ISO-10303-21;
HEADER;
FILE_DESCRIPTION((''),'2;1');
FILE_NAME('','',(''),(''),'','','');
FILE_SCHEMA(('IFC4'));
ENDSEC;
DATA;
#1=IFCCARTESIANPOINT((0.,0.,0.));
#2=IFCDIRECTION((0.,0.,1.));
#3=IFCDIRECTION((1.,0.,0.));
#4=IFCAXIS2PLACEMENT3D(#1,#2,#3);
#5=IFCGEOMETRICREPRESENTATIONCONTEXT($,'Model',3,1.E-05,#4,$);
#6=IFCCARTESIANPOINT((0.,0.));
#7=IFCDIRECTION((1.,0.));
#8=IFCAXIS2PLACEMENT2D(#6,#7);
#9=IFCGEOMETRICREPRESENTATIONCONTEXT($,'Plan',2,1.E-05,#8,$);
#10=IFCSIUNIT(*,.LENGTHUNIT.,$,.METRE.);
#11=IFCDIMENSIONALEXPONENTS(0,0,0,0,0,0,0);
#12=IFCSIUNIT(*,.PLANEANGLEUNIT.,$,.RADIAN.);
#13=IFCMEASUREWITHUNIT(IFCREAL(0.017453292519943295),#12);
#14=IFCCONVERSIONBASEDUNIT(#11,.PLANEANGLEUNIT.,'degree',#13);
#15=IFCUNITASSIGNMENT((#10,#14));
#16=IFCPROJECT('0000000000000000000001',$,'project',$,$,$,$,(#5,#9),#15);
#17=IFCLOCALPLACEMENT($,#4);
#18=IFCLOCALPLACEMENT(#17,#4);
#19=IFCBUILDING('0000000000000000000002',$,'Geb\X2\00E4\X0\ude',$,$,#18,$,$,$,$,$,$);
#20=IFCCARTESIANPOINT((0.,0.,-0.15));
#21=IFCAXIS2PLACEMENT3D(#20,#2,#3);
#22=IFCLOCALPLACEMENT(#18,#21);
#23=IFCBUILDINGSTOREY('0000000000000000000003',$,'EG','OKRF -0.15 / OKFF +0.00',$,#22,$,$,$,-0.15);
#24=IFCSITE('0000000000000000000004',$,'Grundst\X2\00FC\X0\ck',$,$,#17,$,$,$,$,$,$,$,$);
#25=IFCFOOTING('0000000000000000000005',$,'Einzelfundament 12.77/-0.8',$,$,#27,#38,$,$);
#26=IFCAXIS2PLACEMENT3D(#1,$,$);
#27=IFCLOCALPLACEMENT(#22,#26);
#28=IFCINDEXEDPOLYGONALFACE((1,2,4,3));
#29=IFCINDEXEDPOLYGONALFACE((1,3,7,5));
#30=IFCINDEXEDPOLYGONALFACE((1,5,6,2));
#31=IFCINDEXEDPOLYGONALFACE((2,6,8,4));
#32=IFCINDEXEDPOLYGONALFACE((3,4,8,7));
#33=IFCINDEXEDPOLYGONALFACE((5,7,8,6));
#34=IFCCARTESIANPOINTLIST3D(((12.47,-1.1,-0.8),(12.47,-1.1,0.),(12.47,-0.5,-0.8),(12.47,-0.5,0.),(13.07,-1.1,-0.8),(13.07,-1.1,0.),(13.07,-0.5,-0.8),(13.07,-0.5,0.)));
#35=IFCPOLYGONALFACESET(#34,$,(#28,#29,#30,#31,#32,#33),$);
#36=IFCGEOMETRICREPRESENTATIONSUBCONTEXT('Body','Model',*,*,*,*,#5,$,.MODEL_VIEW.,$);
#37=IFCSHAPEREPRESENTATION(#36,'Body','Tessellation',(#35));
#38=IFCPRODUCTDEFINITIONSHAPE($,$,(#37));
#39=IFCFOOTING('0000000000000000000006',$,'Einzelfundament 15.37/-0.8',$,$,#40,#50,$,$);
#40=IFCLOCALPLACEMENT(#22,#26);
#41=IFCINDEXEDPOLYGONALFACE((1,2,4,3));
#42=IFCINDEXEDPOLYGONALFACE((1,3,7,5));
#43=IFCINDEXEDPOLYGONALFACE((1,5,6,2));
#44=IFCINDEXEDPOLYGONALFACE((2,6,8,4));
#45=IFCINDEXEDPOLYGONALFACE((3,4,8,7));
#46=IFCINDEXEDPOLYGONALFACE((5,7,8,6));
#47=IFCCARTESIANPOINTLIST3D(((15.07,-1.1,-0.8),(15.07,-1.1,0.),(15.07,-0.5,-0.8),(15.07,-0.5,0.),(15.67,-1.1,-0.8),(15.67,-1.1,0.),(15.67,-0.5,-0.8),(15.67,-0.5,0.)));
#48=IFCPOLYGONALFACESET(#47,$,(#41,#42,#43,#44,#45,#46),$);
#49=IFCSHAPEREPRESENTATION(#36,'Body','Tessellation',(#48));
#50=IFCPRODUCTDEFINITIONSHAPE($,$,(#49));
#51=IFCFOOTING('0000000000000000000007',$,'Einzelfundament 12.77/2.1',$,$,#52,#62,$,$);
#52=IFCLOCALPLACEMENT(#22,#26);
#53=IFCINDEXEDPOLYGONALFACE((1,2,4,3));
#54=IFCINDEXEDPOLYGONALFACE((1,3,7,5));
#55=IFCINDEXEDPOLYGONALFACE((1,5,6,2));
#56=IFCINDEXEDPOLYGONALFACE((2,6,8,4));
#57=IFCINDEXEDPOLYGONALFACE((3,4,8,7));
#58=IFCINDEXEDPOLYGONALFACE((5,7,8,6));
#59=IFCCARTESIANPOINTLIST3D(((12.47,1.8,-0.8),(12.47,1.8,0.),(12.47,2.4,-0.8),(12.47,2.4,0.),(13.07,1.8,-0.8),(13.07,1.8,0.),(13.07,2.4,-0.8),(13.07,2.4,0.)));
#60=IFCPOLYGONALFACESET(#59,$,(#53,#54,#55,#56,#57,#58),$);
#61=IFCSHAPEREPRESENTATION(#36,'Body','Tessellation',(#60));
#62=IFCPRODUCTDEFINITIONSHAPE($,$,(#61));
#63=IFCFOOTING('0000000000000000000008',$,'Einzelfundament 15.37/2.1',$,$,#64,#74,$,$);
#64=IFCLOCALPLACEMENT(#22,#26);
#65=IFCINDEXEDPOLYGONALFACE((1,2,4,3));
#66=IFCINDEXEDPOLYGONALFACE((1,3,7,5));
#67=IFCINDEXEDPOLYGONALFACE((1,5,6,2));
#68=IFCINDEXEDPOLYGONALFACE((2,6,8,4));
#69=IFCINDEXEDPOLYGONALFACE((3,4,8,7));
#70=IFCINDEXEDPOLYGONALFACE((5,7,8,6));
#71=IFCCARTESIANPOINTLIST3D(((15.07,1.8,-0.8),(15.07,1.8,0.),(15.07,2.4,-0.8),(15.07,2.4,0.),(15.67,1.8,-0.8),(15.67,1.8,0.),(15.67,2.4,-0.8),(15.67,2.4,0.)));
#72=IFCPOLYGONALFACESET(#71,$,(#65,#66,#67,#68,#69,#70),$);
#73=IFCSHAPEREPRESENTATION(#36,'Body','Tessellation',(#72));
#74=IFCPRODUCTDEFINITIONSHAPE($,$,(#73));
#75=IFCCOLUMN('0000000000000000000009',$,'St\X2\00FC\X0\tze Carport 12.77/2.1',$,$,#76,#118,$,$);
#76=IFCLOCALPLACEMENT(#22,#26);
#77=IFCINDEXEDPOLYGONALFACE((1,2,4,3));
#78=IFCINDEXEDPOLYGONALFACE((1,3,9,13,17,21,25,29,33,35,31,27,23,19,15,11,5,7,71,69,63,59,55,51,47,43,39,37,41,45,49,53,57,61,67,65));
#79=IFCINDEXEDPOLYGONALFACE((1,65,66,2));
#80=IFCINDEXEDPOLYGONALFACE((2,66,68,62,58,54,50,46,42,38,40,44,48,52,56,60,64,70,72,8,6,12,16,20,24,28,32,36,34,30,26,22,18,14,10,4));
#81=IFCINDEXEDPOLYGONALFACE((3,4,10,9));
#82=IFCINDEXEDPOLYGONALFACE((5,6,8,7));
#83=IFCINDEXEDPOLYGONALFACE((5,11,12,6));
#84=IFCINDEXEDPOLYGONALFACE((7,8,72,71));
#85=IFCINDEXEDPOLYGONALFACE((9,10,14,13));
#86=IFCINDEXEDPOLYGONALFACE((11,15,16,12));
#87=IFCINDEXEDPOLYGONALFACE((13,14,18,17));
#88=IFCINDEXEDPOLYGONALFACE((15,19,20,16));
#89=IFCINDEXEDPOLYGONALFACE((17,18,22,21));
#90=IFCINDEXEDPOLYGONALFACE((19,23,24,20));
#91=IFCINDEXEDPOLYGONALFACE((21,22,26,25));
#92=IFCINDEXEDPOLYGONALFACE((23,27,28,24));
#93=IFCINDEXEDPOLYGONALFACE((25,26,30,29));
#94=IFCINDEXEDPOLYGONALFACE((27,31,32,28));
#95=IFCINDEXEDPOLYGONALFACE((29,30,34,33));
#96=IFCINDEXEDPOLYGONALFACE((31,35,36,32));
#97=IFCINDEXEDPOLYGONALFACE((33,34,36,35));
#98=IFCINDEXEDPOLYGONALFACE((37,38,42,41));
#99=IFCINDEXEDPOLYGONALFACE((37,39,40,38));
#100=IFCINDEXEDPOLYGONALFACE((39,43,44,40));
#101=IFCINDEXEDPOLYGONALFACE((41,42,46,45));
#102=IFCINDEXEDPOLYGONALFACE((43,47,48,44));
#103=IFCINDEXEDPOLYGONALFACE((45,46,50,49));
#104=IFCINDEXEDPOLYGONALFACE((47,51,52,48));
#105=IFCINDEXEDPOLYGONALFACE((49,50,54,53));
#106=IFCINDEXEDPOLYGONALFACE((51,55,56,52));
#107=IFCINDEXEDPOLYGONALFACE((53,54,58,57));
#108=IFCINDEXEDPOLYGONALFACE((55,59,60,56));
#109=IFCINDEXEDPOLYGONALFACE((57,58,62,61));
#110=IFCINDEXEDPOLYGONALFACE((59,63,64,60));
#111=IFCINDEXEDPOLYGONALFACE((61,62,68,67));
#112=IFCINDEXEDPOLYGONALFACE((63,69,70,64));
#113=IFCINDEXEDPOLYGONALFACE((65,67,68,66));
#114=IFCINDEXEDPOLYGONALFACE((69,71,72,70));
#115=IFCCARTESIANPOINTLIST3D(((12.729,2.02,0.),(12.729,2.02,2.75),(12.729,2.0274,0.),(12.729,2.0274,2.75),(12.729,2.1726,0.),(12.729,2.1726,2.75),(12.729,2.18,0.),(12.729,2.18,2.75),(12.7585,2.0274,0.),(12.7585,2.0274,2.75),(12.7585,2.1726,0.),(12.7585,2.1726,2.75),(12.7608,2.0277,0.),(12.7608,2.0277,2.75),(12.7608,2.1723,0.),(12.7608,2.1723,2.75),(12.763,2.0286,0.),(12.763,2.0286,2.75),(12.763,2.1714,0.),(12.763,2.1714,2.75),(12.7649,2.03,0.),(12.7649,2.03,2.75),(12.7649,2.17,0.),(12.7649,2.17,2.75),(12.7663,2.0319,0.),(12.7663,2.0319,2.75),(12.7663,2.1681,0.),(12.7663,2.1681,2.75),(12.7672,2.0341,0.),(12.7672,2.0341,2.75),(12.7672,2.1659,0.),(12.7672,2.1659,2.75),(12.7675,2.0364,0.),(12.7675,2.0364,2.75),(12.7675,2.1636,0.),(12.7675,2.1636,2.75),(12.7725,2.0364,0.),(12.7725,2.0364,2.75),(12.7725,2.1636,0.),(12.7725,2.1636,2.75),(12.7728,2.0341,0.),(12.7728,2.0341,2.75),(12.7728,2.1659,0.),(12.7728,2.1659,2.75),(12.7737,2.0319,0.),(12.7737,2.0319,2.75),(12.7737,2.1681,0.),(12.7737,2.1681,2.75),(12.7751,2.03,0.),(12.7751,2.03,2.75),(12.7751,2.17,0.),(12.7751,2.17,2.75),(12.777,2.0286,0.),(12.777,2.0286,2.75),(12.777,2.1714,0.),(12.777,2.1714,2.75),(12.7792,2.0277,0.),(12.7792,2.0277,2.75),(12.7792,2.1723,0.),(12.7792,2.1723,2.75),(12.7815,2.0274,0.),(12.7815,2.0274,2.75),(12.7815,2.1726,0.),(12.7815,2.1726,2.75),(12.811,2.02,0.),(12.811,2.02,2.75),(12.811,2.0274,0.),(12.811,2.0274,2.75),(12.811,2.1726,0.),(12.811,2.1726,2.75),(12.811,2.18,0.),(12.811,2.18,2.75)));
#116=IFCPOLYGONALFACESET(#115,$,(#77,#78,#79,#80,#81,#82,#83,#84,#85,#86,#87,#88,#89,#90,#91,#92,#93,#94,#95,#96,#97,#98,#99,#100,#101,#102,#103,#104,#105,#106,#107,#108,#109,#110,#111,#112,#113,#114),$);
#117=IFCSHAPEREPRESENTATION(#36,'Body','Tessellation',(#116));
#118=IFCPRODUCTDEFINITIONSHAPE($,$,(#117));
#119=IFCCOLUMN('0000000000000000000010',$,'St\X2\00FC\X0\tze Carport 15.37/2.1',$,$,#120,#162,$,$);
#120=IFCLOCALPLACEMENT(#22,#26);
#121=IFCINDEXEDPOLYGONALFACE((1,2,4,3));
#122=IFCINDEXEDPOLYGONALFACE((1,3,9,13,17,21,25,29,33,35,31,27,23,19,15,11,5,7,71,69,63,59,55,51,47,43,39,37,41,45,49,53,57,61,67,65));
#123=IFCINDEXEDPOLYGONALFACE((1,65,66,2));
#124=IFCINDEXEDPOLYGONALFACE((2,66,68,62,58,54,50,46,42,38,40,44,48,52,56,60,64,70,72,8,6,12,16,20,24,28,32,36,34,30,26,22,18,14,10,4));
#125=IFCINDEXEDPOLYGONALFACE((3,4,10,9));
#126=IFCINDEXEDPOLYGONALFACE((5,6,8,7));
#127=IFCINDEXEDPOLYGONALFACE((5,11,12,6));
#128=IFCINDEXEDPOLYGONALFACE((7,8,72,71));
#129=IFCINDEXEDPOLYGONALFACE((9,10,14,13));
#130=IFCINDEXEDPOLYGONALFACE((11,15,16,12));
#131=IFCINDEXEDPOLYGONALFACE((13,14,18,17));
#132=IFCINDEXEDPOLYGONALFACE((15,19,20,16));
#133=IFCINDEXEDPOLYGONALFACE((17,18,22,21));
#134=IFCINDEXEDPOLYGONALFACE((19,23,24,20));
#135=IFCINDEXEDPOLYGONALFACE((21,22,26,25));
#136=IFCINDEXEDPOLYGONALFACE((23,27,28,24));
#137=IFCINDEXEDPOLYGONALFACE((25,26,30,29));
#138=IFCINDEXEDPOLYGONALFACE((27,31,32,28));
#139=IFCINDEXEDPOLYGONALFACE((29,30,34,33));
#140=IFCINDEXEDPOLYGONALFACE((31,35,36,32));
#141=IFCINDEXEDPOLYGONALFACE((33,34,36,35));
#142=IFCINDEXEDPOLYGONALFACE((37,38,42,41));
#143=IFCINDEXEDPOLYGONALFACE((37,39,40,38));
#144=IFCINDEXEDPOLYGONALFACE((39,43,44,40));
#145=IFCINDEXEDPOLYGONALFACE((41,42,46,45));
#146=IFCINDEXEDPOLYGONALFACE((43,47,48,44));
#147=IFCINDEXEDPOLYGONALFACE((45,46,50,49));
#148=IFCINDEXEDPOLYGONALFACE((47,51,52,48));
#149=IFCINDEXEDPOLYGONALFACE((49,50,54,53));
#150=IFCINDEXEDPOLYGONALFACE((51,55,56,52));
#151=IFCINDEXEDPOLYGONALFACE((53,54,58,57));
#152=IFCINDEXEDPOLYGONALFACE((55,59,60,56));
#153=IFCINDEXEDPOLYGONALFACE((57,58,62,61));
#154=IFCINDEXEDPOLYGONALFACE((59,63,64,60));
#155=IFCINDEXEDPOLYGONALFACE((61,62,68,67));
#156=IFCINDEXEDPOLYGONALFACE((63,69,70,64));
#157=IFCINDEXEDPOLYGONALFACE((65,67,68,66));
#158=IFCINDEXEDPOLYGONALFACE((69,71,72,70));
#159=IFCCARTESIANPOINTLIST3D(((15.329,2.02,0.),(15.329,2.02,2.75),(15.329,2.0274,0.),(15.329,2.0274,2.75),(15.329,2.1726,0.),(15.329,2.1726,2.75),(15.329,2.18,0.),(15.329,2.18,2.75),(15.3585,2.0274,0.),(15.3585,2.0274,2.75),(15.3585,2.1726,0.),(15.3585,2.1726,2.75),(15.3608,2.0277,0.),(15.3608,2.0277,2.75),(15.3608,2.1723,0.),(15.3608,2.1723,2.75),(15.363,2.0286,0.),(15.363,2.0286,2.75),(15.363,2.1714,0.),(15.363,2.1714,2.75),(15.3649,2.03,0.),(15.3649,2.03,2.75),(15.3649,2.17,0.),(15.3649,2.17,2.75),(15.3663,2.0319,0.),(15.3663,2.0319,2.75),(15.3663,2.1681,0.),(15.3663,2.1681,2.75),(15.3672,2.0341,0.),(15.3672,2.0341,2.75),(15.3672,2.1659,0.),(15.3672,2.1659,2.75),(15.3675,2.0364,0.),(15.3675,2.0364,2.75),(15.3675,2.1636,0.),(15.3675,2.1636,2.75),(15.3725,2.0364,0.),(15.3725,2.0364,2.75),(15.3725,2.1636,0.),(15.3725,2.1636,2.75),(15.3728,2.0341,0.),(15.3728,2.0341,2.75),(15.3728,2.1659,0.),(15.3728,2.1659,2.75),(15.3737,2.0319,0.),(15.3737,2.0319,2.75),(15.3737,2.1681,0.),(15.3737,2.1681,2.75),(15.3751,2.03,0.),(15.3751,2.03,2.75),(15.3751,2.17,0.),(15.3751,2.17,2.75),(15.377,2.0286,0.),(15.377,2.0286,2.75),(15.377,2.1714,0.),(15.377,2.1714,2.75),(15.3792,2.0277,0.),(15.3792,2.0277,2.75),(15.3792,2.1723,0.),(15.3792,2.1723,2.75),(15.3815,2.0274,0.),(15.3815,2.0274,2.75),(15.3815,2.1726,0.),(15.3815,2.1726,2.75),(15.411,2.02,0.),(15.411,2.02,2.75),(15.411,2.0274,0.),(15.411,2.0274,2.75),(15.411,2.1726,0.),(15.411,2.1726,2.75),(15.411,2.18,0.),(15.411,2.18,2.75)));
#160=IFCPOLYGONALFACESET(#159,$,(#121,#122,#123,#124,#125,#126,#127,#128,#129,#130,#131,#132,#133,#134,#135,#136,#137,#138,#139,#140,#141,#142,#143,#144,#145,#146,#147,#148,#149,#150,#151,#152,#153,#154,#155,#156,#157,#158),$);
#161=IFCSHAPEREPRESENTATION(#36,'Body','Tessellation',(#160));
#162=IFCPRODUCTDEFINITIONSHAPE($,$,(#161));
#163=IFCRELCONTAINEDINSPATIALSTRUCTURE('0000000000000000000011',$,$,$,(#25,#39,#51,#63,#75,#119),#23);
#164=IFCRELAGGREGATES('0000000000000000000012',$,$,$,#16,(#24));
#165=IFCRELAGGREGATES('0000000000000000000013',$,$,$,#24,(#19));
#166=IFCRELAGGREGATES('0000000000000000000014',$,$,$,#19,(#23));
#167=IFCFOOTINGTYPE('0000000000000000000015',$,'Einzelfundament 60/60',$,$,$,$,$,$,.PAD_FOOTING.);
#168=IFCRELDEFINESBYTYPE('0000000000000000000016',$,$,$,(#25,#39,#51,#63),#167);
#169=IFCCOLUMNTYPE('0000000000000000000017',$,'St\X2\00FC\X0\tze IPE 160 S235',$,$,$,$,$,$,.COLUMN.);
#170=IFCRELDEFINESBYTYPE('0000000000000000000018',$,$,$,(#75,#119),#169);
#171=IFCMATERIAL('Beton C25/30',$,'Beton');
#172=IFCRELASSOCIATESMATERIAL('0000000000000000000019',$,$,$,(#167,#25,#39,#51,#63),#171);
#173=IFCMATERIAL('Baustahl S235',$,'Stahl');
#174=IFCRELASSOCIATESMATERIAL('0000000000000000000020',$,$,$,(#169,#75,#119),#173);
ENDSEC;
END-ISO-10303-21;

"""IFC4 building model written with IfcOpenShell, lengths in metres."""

from ifc_helpers import new_model, entity, si_unit, converted_unit, frame, origin_with_axes, origin_2d_with_axis, place, context, subcontext, project, spatial, rectangle, i_section, extrude, material, material_profile, profile_set, profile_usage, type_object, element, save


model = new_model("IFC4")

# Units and contexts
model_context = context("Model", 3, precision=1e-05, world=origin_with_axes())
plan_context = context("Plan", 2, precision=1e-05, world=origin_2d_with_axis())
body_context = subcontext(model_context, "Body", "Model", "MODEL_VIEW")
ifc_project = project(units=[si_unit("LENGTHUNIT", "METRE"), converted_unit("PLANEANGLEUNIT", "degree", entity("IfcReal", 0.017453292519943295), si_unit("PLANEANGLEUNIT", "RADIAN"), dimensions=[0, 0, 0, 0, 0, 0, 0])], contexts=[model_context, plan_context])

# Site, building, storey
site_placement = place(None, origin_with_axes())
site = spatial("IfcSite", under=ifc_project, at=site_placement, Name="Grundstück")
building_placement = place(site_placement, origin_with_axes())
building = spatial("IfcBuilding", under=site, at=building_placement, Name="Gebäude")
storey_placement = place(building_placement, frame((0.0, 0.0, -0.15), z_axis=(0.0, 0.0, 1.0), x_axis=(1.0, 0.0, 0.0)))
storey = spatial("IfcBuildingStorey", under=building, at=storey_placement, Name="EG", Description="OKRF -0.15 / OKFF +0.00", Elevation=-0.15)

# Footings
ifc_material_1 = material(Name="Beton C25/30", Category="Beton")
ifc_material_profile_1 = material_profile(ifc_material_1, rectangle(XDim=0.6, YDim=0.6))
ifc_profile_set_1 = profile_set([ifc_material_profile_1], Name="Einzelfundament 60/60")
ifc_profile_usage_1 = profile_usage(ifc_profile_set_1)
footing_type = type_object("IfcFootingType", Name="Einzelfundament 60/60", PredefinedType="PAD_FOOTING", material=ifc_profile_set_1)
footing_1_placement = place(storey_placement, frame((12.77, -0.8, -0.8), z_axis=(0.0, 0.0, 1.0), x_axis=(1.0, 0.0, 0.0)))
element("IfcFooting", 1, at=footing_1_placement, inside=storey, type_object=footing_type, material=ifc_profile_usage_1, Name="Einzelfundament 12.77/-0.8", context=body_context, shape_type="SweptSolid", body=[
    extrude(rectangle(XDim=0.6, YDim=0.6), origin_with_axes(), (0.0, 0.0, 1.0), 0.8),
])
ifc_profile_usage_2 = profile_usage(ifc_profile_set_1)
footing_2_placement = place(storey_placement, frame((15.37, -0.8, -0.8), z_axis=(0.0, 0.0, 1.0), x_axis=(1.0, 0.0, 0.0)))
element("IfcFooting", 2, at=footing_2_placement, inside=storey, type_object=footing_type, material=ifc_profile_usage_2, Name="Einzelfundament 15.37/-0.8", context=body_context, shape_type="SweptSolid", body=[
    extrude(rectangle(XDim=0.6, YDim=0.6), origin_with_axes(), (0.0, 0.0, 1.0), 0.8),
])
ifc_profile_usage_3 = profile_usage(ifc_profile_set_1)
footing_3_placement = place(storey_placement, frame((12.77, 2.1, -0.8), z_axis=(0.0, 0.0, 1.0), x_axis=(1.0, 0.0, 0.0)))
element("IfcFooting", 3, at=footing_3_placement, inside=storey, type_object=footing_type, material=ifc_profile_usage_3, Name="Einzelfundament 12.77/2.1", context=body_context, shape_type="SweptSolid", body=[
    extrude(rectangle(XDim=0.6, YDim=0.6), origin_with_axes(), (0.0, 0.0, 1.0), 0.8),
])
ifc_profile_usage_4 = profile_usage(ifc_profile_set_1)
footing_4_placement = place(storey_placement, frame((15.37, 2.1, -0.8), z_axis=(0.0, 0.0, 1.0), x_axis=(1.0, 0.0, 0.0)))
element("IfcFooting", 4, at=footing_4_placement, inside=storey, type_object=footing_type, material=ifc_profile_usage_4, Name="Einzelfundament 15.37/2.1", context=body_context, shape_type="SweptSolid", body=[
    extrude(rectangle(XDim=0.6, YDim=0.6), origin_with_axes(), (0.0, 0.0, 1.0), 0.8),
])

# Columns
ifc_material_2 = material(Name="Baustahl S235", Category="Stahl")
ifc_material_profile_2 = material_profile(ifc_material_2, i_section(OverallWidth=0.082, OverallDepth=0.16, WebThickness=0.005, FlangeThickness=0.0074, FilletRadius=0.009))
ifc_profile_set_2 = profile_set([ifc_material_profile_2], Name="Stütze IPE 160 S235")
ifc_profile_usage_5 = profile_usage(ifc_profile_set_2)
column_type_1 = type_object("IfcColumnType", Name="Stütze IPE 160 S235", PredefinedType="COLUMN", material=ifc_profile_set_2)
column_1_placement = place(storey_placement, frame((12.77, 2.1, 0.0), z_axis=(0.0, 0.0, 1.0), x_axis=(1.0, 0.0, 0.0)))
element("IfcColumn", 5, at=column_1_placement, inside=storey, type_object=column_type_1, material=ifc_profile_usage_5, Name="Stütze Carport 12.77/2.1", context=body_context, shape_type="SweptSolid", body=[
    extrude(i_section(OverallWidth=0.082, OverallDepth=0.16, WebThickness=0.005, FlangeThickness=0.0074, FilletRadius=0.009), origin_with_axes(), (0.0, 0.0, 1.0), 2.75),
])
ifc_profile_usage_6 = profile_usage(ifc_profile_set_2)
column_2_placement = place(storey_placement, frame((15.37, 2.1, 0.0), z_axis=(0.0, 0.0, 1.0), x_axis=(1.0, 0.0, 0.0)))
element("IfcColumn", 6, at=column_2_placement, inside=storey, type_object=column_type_1, material=ifc_profile_usage_6, Name="Stütze Carport 15.37/2.1", context=body_context, shape_type="SweptSolid", body=[
    extrude(i_section(OverallWidth=0.082, OverallDepth=0.16, WebThickness=0.005, FlangeThickness=0.0074, FilletRadius=0.009), origin_with_axes(), (0.0, 0.0, 1.0), 2.75),
])

save(model, "model.ifc")
